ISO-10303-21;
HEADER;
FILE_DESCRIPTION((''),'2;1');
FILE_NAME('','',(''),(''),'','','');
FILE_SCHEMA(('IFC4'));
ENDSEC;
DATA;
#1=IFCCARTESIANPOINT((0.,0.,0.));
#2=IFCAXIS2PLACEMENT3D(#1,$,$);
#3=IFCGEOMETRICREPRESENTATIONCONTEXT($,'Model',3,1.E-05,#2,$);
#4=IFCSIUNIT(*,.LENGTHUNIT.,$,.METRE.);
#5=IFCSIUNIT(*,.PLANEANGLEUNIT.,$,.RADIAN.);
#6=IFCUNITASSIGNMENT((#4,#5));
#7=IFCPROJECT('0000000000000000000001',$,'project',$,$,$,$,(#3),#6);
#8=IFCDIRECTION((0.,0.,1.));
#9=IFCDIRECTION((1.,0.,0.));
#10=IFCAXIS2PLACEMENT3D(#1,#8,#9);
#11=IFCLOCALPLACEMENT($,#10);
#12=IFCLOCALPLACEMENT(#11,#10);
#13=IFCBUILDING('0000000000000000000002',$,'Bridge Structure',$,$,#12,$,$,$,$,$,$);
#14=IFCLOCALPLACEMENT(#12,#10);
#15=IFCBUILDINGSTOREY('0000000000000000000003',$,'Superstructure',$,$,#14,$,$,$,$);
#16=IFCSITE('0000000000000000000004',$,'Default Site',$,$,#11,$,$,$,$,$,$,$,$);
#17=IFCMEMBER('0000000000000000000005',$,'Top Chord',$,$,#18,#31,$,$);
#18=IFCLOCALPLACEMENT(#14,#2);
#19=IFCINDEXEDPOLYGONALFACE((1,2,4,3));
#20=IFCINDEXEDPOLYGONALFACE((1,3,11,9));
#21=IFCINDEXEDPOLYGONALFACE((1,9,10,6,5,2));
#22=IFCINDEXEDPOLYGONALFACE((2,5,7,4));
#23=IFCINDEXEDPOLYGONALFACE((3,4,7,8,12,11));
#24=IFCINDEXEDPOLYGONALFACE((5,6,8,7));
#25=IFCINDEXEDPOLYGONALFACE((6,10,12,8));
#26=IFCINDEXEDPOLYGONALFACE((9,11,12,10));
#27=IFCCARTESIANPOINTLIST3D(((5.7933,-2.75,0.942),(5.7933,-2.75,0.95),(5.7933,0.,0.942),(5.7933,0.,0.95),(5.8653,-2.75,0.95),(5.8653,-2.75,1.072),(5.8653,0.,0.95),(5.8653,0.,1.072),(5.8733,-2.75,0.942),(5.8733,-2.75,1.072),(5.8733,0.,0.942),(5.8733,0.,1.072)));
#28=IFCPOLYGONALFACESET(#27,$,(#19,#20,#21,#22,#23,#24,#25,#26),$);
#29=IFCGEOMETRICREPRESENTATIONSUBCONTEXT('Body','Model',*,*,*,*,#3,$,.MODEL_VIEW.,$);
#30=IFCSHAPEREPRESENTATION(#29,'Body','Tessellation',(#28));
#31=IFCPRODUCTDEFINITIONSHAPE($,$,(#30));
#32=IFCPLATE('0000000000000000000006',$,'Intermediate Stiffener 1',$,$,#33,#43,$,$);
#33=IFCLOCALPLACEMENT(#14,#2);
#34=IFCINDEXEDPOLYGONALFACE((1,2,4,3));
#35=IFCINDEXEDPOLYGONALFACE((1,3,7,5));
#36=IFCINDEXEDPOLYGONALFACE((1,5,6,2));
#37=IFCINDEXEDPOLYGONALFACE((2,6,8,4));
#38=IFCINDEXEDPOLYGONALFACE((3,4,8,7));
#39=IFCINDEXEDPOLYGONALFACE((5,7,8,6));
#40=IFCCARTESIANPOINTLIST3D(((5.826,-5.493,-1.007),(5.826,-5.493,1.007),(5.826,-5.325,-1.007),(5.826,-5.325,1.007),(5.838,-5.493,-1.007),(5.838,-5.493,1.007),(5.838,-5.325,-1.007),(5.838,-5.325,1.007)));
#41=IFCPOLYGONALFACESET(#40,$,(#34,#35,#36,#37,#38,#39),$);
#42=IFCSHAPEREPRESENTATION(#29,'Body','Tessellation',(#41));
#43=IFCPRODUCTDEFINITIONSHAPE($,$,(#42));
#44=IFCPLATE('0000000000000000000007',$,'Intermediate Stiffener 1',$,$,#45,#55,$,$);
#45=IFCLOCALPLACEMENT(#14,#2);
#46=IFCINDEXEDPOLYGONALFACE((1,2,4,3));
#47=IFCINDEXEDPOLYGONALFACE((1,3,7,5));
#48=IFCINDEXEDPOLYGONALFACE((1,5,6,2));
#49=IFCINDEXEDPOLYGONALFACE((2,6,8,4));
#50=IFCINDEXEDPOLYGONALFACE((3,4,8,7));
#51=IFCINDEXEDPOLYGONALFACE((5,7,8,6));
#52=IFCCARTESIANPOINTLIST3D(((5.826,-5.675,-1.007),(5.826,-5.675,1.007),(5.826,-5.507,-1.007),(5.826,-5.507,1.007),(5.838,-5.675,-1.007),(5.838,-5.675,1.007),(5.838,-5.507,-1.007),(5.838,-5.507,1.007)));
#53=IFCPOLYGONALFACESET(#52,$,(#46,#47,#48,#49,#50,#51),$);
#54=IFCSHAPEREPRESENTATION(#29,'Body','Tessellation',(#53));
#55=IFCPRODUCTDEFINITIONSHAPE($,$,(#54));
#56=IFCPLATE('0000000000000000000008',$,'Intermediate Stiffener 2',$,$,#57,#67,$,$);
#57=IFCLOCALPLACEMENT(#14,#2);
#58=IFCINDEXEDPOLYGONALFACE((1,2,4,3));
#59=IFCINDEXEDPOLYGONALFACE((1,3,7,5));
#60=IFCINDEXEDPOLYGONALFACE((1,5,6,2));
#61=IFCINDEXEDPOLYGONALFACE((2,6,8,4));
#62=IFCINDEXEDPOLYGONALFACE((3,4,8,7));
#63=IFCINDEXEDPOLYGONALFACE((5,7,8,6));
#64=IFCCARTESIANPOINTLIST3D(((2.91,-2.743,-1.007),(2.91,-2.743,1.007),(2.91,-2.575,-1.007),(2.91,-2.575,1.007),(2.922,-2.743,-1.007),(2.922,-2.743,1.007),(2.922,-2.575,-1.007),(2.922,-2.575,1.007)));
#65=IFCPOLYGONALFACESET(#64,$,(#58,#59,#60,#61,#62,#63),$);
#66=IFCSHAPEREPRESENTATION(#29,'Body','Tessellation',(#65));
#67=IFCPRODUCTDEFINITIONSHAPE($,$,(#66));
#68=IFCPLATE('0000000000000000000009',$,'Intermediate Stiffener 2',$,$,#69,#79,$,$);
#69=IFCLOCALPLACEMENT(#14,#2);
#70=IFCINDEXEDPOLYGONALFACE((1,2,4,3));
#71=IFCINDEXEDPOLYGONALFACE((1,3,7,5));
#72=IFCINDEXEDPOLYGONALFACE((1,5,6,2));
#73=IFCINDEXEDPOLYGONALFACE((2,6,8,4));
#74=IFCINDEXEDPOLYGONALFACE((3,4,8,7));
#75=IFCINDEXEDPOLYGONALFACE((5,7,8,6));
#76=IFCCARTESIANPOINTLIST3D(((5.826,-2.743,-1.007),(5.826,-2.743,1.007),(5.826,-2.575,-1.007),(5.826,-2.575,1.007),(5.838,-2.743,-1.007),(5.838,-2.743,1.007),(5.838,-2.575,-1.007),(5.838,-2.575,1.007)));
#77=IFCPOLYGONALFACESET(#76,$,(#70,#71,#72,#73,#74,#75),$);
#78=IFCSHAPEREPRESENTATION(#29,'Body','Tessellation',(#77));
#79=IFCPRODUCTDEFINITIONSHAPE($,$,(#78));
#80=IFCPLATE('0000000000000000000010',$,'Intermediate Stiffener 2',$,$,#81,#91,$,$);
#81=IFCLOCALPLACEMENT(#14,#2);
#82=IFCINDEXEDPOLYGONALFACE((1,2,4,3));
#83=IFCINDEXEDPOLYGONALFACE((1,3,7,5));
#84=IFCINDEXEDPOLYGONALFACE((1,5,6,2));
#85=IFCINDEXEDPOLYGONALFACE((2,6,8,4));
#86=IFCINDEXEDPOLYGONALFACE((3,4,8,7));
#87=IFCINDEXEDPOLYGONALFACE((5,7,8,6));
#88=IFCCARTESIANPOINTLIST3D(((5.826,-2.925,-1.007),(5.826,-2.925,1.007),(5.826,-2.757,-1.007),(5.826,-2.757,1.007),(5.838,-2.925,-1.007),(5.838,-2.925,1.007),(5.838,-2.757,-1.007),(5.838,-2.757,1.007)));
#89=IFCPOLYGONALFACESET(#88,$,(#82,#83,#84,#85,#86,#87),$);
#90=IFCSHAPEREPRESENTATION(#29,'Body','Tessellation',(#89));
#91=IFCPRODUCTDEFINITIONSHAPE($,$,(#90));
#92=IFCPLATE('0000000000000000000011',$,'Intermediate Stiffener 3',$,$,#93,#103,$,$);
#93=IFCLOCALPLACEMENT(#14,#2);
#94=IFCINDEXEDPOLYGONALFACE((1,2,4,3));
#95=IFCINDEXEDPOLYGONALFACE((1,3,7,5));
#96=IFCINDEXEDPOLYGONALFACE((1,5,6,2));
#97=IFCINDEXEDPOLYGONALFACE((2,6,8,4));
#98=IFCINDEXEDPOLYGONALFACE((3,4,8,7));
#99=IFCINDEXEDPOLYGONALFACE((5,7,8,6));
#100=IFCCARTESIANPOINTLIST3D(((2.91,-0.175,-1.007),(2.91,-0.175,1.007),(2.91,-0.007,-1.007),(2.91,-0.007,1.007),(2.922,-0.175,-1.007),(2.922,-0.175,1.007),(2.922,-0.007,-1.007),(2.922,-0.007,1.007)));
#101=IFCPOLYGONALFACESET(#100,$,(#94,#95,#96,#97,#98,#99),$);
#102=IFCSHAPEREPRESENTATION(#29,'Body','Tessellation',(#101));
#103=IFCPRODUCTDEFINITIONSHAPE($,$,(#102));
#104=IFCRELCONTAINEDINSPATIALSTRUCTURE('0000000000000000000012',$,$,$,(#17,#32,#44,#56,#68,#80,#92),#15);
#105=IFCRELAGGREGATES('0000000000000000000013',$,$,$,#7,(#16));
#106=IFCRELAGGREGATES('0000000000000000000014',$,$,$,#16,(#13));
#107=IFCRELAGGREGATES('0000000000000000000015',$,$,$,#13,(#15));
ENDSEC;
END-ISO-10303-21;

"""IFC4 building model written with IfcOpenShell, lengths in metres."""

from ifc_helpers import new_model, si_unit, frame, origin, origin_with_axes, origin_2d_with_axis, place, context, subcontext, project, spatial, rectangle, l_section, extrude, element, save


model = new_model("IFC4")

# Units and contexts
model_context = context("Model", 3, precision=1e-05, world=origin())
body_context = subcontext(model_context, "Body", "Model", "MODEL_VIEW")
ifc_project = project(units=[si_unit("LENGTHUNIT", "METRE"), si_unit("PLANEANGLEUNIT", "RADIAN")], contexts=[model_context])

# Site, building, storey
site_placement = place(None, origin_with_axes())
site = spatial("IfcSite", under=ifc_project, at=site_placement, Name="Default Site")
building_placement = place(site_placement, origin_with_axes())
building = spatial("IfcBuilding", under=site, at=building_placement, Name="Bridge Structure")
storey_placement = place(building_placement, origin_with_axes())
storey = spatial("IfcBuildingStorey", under=building, at=storey_placement, Name="Superstructure")

# Member
for number, where, z_axis, x_axis, name in (
    (1, (5.8333, -2.75, 1.007), (0.0, 1.0, 0.0), (-1.0, 0.0, 0.0), "Top Chord"),
):
    element("IfcMember", number, at=place(storey_placement, frame(where, z_axis=z_axis, x_axis=x_axis)), inside=storey, Name=name, context=body_context, shape_type="SweptSolid", body=[
        extrude(l_section(Depth=0.13, Width=0.08, Thickness=0.008, at=origin_2d_with_axis()), origin_with_axes(), (0.0, 0.0, 1.0), 2.75),
    ])

# Plates
for number, where, z_axis, x_axis, name in (
    (2, (5.832, -5.409, -1.007), (0.0, 0.0, 1.0), (1.0, 0.0, 0.0), "Intermediate Stiffener 1"),
    (3, (5.832, -5.591, -1.007), (0.0, 0.0, 1.0), (1.0, 0.0, 0.0), "Intermediate Stiffener 1"),
    (4, (2.916, -2.659, -1.007), (0.0, 0.0, 1.0), (1.0, 0.0, 0.0), "Intermediate Stiffener 2"),
    (5, (5.832, -2.659, -1.007), (0.0, 0.0, 1.0), (1.0, 0.0, 0.0), "Intermediate Stiffener 2"),
    (6, (5.832, -2.841, -1.007), (0.0, 0.0, 1.0), (1.0, 0.0, 0.0), "Intermediate Stiffener 2"),
    (7, (2.916, -0.091, -1.007), (0.0, 0.0, 1.0), (1.0, 0.0, 0.0), "Intermediate Stiffener 3"),
):
    element("IfcPlate", number, at=place(storey_placement, frame(where, z_axis=z_axis, x_axis=x_axis)), inside=storey, Name=name, context=body_context, shape_type="SweptSolid", body=[
        extrude(rectangle(XDim=0.012, YDim=0.168, at=origin_2d_with_axis()), origin_with_axes(), (0.0, 0.0, 1.0), 2.014),
    ])

save(model, "model.ifc")
